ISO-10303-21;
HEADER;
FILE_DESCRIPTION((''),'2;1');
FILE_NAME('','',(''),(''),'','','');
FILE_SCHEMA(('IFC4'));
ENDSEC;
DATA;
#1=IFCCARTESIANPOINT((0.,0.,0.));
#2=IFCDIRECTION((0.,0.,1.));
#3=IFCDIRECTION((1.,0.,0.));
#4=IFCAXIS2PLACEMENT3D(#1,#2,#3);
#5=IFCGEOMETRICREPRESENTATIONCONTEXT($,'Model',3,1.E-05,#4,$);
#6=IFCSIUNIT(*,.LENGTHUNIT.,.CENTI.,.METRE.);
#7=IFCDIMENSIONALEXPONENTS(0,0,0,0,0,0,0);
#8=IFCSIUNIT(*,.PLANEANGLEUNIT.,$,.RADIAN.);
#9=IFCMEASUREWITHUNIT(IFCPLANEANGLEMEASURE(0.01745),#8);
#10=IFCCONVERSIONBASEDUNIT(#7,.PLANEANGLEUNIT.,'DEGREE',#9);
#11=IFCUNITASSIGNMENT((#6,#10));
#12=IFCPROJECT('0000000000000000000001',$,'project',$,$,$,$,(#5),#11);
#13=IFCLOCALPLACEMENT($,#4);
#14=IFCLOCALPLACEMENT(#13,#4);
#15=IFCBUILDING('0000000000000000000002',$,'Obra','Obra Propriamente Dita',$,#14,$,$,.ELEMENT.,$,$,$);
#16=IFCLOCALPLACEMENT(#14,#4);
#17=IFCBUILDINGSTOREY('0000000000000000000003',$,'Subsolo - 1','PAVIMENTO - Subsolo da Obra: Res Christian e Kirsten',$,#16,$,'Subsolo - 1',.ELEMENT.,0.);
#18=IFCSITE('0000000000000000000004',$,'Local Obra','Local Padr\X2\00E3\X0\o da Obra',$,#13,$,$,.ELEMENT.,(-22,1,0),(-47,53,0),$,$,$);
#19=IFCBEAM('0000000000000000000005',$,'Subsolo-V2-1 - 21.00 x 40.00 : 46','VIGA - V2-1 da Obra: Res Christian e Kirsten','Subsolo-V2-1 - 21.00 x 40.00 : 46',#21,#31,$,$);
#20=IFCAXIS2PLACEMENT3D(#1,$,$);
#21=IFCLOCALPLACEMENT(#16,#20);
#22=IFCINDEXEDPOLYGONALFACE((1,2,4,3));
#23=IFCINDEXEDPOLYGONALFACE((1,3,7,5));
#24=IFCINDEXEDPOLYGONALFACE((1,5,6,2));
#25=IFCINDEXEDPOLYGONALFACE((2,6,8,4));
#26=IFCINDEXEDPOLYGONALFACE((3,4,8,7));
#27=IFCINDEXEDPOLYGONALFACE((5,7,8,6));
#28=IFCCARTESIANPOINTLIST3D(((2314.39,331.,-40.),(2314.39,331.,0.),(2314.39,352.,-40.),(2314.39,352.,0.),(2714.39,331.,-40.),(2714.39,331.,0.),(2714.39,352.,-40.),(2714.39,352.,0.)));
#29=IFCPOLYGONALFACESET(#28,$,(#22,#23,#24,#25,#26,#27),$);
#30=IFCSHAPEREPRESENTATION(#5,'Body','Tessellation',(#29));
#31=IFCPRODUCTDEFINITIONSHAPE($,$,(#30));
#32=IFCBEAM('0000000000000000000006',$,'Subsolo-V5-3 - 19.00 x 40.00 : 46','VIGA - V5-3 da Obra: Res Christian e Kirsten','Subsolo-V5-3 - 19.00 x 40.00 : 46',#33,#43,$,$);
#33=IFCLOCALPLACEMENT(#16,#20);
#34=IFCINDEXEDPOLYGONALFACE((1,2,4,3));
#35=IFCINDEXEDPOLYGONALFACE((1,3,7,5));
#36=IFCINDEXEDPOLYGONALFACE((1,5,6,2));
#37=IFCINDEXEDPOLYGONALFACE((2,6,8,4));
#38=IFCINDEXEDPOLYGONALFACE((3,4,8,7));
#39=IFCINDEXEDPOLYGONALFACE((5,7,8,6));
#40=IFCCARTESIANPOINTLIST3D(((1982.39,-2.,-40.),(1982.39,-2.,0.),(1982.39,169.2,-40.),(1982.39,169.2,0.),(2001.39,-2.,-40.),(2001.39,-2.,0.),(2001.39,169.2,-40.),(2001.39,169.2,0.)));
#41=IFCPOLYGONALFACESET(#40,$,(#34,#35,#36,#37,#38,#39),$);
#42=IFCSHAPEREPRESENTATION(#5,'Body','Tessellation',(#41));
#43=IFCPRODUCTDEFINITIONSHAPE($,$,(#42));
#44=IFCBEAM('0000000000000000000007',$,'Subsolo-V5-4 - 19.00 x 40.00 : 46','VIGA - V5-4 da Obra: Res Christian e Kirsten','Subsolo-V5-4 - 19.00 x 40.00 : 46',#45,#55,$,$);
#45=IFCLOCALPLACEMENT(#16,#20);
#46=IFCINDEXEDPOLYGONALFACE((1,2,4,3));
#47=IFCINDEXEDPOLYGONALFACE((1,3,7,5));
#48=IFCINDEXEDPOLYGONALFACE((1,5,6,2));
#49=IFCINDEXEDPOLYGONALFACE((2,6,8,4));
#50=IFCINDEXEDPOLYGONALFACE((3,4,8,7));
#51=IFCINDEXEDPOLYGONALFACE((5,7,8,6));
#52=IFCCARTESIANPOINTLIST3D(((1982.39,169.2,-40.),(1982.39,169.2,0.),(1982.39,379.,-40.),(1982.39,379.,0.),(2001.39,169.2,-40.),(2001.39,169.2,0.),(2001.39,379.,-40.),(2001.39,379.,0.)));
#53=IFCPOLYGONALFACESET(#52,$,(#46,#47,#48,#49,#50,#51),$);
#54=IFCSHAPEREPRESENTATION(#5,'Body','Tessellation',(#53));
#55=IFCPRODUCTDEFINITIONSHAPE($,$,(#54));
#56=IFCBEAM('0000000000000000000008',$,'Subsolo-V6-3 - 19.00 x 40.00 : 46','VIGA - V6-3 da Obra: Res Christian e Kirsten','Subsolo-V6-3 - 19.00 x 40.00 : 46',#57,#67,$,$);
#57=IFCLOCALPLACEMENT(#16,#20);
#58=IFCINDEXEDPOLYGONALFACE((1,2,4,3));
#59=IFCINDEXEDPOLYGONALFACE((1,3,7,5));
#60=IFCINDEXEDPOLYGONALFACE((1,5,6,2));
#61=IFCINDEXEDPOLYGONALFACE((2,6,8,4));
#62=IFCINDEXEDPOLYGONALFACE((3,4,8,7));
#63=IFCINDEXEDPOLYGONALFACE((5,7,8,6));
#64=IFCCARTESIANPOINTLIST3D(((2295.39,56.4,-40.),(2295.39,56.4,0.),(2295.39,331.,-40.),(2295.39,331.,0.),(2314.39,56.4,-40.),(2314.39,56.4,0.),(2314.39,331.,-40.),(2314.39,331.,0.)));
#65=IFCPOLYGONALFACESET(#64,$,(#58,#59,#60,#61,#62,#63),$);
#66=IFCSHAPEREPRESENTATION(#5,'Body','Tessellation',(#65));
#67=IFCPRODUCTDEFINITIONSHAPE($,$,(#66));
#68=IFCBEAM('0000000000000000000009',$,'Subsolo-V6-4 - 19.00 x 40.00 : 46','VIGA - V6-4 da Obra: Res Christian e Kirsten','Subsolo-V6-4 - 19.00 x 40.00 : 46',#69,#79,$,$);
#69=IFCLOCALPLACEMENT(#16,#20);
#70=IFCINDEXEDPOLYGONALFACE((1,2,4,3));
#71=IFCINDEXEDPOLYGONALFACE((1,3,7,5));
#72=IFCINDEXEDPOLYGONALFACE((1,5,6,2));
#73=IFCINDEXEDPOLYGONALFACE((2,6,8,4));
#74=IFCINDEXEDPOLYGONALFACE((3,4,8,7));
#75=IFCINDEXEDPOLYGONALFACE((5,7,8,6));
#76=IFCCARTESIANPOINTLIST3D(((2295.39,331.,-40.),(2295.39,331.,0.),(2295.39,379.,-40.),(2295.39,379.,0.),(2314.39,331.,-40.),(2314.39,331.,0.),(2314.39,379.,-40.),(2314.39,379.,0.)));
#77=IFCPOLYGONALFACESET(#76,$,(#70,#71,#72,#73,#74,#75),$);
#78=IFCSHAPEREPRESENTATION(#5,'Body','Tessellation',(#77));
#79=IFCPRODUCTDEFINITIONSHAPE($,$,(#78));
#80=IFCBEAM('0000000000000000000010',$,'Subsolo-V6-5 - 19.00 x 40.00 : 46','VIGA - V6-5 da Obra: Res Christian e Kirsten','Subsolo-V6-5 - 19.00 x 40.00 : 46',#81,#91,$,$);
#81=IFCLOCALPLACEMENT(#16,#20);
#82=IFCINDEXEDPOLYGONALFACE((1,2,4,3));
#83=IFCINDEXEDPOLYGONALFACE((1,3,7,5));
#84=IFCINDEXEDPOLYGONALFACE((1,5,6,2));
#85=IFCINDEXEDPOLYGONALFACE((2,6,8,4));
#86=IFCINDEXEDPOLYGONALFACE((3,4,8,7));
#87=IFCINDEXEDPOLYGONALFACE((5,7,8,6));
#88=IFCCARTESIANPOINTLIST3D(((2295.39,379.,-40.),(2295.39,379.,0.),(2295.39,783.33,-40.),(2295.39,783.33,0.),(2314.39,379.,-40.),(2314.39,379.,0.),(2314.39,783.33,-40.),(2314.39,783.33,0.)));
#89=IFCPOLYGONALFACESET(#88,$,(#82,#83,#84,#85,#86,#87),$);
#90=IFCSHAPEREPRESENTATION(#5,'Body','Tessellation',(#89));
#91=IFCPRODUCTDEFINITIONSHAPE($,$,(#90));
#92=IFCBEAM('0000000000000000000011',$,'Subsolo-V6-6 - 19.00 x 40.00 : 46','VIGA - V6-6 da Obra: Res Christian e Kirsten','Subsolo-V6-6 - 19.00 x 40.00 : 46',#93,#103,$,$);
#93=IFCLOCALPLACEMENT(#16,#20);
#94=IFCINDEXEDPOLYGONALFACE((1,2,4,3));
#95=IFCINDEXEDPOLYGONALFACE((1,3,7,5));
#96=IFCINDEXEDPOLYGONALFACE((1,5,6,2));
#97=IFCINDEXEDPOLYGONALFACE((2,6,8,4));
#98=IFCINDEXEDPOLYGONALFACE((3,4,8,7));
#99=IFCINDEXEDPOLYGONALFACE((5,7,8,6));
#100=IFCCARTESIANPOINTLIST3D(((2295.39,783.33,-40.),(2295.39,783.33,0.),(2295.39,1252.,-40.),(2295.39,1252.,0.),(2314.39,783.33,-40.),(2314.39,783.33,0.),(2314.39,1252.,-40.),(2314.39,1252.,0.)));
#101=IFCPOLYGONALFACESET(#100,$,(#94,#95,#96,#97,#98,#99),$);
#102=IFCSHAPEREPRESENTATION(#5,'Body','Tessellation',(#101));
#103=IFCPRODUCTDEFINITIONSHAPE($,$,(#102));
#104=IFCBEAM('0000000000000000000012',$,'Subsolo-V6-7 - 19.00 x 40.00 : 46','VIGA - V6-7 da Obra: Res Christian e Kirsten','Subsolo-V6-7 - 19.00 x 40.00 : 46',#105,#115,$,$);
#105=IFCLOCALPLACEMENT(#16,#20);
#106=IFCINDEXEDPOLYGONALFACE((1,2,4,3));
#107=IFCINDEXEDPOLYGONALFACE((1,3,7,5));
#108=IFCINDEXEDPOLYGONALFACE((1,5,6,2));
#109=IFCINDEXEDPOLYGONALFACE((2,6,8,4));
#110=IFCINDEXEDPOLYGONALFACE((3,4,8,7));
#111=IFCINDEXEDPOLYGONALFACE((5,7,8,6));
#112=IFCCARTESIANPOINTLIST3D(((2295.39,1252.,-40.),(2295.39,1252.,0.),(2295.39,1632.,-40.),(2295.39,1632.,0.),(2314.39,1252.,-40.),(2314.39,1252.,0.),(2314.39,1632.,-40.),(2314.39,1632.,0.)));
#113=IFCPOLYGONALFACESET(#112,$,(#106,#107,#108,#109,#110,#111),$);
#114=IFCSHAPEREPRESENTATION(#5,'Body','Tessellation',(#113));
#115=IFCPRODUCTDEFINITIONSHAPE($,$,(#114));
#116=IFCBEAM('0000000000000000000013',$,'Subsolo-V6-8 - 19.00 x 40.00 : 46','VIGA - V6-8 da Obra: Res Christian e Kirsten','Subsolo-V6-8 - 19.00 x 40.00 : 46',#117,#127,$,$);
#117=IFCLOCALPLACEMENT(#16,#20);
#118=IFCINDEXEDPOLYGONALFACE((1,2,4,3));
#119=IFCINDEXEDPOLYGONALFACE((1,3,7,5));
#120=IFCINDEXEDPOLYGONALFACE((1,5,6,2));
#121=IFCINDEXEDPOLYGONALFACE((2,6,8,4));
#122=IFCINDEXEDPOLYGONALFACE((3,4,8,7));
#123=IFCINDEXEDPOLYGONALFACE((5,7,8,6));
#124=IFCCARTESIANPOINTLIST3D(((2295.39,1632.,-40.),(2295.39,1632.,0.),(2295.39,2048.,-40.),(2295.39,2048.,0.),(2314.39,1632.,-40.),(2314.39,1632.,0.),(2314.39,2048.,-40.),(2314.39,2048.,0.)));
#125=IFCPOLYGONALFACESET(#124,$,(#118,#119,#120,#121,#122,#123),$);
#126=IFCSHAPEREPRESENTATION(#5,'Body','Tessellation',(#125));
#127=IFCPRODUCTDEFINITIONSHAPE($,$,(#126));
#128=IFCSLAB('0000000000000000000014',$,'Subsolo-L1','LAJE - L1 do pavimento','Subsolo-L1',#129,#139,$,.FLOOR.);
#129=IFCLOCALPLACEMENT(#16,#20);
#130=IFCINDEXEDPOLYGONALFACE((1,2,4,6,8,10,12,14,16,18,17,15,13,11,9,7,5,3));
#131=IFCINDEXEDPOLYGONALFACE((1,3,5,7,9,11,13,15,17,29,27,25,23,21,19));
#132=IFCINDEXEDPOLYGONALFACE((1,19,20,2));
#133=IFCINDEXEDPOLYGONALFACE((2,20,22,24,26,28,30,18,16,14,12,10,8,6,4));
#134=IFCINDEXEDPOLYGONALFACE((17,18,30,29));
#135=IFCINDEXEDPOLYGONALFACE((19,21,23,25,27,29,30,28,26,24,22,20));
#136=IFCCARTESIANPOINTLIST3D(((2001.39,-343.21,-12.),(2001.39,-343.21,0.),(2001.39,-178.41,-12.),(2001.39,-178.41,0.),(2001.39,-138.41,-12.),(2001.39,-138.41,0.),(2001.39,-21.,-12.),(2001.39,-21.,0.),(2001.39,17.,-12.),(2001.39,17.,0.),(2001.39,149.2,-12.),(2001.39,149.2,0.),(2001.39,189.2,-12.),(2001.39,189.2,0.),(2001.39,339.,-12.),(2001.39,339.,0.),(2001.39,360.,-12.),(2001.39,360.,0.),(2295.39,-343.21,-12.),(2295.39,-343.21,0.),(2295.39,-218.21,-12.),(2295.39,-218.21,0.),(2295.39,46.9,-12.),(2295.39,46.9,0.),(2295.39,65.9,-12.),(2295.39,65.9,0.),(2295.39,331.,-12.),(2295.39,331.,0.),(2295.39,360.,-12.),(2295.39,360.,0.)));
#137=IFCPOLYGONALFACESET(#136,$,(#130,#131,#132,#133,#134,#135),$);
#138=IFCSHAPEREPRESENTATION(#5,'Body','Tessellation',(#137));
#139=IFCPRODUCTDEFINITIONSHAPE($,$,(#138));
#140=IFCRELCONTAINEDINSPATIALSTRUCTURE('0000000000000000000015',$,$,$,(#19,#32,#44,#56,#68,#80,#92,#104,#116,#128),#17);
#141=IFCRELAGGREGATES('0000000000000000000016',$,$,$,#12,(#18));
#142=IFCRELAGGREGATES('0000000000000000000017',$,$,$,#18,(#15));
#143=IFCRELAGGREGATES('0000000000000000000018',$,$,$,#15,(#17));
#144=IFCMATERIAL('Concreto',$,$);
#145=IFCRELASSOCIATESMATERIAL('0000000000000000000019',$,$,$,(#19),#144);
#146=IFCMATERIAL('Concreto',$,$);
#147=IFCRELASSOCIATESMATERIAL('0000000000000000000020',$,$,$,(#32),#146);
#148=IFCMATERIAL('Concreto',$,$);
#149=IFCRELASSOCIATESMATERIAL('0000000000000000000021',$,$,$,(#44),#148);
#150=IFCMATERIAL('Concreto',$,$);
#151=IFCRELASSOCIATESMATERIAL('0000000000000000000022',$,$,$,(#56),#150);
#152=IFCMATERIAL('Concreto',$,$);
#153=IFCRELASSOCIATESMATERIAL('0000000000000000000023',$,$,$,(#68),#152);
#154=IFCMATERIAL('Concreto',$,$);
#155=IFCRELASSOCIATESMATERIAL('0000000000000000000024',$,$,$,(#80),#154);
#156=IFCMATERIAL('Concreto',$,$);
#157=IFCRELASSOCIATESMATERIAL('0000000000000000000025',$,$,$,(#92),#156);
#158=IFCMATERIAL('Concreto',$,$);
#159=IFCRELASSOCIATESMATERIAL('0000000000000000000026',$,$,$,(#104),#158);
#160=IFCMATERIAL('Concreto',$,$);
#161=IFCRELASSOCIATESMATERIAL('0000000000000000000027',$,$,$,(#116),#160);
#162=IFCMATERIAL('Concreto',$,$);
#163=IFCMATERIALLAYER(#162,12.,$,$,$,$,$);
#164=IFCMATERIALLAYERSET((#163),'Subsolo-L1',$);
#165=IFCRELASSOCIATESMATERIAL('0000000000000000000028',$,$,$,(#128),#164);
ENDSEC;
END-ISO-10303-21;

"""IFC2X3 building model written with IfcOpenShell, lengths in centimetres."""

from ifc_helpers import new_model, entity, si_unit, converted_unit, frame, origin_with_axes, place, context, project, spatial, polyline, outline, extrude, material, layer, layer_set, layer_usage, element, save


model = new_model("IFC2X3")

# Units and contexts
model_context = context("Model", 3, precision=1e-05, world=origin_with_axes())
ifc_project = project(units=[si_unit("LENGTHUNIT", "METRE", prefix="CENTI"), converted_unit("PLANEANGLEUNIT", "DEGREE", entity("IfcPlaneAngleMeasure", 0.01745), si_unit("PLANEANGLEUNIT", "RADIAN"), dimensions=[0, 0, 0, 0, 0, 0, 0])], contexts=[model_context])

# Site, building, storey
site_placement = place(None, origin_with_axes())
site = spatial("IfcSite", under=ifc_project, at=site_placement, Name="Local Obra", Description="Local Padrão da Obra", CompositionType="ELEMENT", RefLatitude=(-22, 1, 0), RefLongitude=(-47, 53, 0))
building_placement = place(site_placement, origin_with_axes())
building = spatial("IfcBuilding", under=site, at=building_placement, Name="Obra", Description="Obra Propriamente Dita", CompositionType="ELEMENT")
storey_placement = place(building_placement, origin_with_axes())
storey = spatial("IfcBuildingStorey", under=building, at=storey_placement, Name="Subsolo - 1", Description="PAVIMENTO - Subsolo da Obra: Res Christian e Kirsten", LongName="Subsolo - 1", CompositionType="ELEMENT", Elevation=0.0)

# Beams
ifc_material_1 = material(Name="Concreto")
beam_1_placement = place(storey_placement, frame((2314.39, 331.0, 0.0), z_axis=(1.0, 0.0, 0.0), x_axis=(0.0, -1.0, 0.0)))
element("IfcBeam", 1, at=beam_1_placement, inside=storey, material=ifc_material_1, Name="Subsolo-V2-1 - 21.00 x 40.00 : 46", Description="VIGA - V2-1 da Obra: Res Christian e Kirsten", ObjectType="Subsolo-V2-1 - 21.00 x 40.00 : 46", context=model_context, shape_type="SweptSolid", body=[
    extrude(outline(polyline([(-21.0, 0.0), (0.0, 0.0), (0.0, 40.0), (-21.0, 40.0), (-21.0, 0.0)])), origin_with_axes(), (0.0, 0.0, 1.0), 400.0),
])
ifc_material_2 = material(Name="Concreto")
beam_2_placement = place(storey_placement, frame((2001.39, -2.0, 0.0), z_axis=(0.0, 1.0, 0.0), x_axis=(1.0, 0.0, 0.0)))
element("IfcBeam", 2, at=beam_2_placement, inside=storey, material=ifc_material_2, Name="Subsolo-V5-3 - 19.00 x 40.00 : 46", Description="VIGA - V5-3 da Obra: Res Christian e Kirsten", ObjectType="Subsolo-V5-3 - 19.00 x 40.00 : 46", context=model_context, shape_type="SweptSolid", body=[
    extrude(outline(polyline([(-19.0, 0.0), (0.0, 0.0), (0.0, 40.0), (-19.0, 40.0), (-19.0, 0.0)])), origin_with_axes(), (0.0, 0.0, 1.0), 171.2),
])
ifc_material_3 = material(Name="Concreto")
beam_3_placement = place(storey_placement, frame((2001.39, 169.2, 0.0), z_axis=(0.0, 1.0, 0.0), x_axis=(1.0, 0.0, 0.0)))
element("IfcBeam", 3, at=beam_3_placement, inside=storey, material=ifc_material_3, Name="Subsolo-V5-4 - 19.00 x 40.00 : 46", Description="VIGA - V5-4 da Obra: Res Christian e Kirsten", ObjectType="Subsolo-V5-4 - 19.00 x 40.00 : 46", context=model_context, shape_type="SweptSolid", body=[
    extrude(outline(polyline([(-19.0, 0.0), (0.0, 0.0), (0.0, 40.0), (-19.0, 40.0), (-19.0, 0.0)])), origin_with_axes(), (0.0, 0.0, 1.0), 209.8),
])
ifc_material_4 = material(Name="Concreto")
beam_4_placement = place(storey_placement, frame((2314.39, 56.4, 0.0), z_axis=(-0.000004, 1.0, 0.0), x_axis=(1.0, 0.000004, 0.0)))
element("IfcBeam", 4, at=beam_4_placement, inside=storey, material=ifc_material_4, Name="Subsolo-V6-3 - 19.00 x 40.00 : 46", Description="VIGA - V6-3 da Obra: Res Christian e Kirsten", ObjectType="Subsolo-V6-3 - 19.00 x 40.00 : 46", context=model_context, shape_type="SweptSolid", body=[
    extrude(outline(polyline([(-19.0, 0.0), (0.0, 0.0), (0.0, 40.0), (-19.0, 40.0), (-19.0, 0.0)])), origin_with_axes(), (0.0, 0.0, 1.0), 274.6),
])
ifc_material_5 = material(Name="Concreto")
beam_5_placement = place(storey_placement, frame((2314.39, 331.0, 0.0), z_axis=(0.0, 1.0, 0.0), x_axis=(1.0, 0.0, 0.0)))
element("IfcBeam", 5, at=beam_5_placement, inside=storey, material=ifc_material_5, Name="Subsolo-V6-4 - 19.00 x 40.00 : 46", Description="VIGA - V6-4 da Obra: Res Christian e Kirsten", ObjectType="Subsolo-V6-4 - 19.00 x 40.00 : 46", context=model_context, shape_type="SweptSolid", body=[
    extrude(outline(polyline([(-19.0, 0.0), (0.0, 0.0), (0.0, 40.0), (-19.0, 40.0), (-19.0, 0.0)])), origin_with_axes(), (0.0, 0.0, 1.0), 48.0),
])
ifc_material_6 = material(Name="Concreto")
beam_6_placement = place(storey_placement, frame((2314.39, 379.0, 0.0), z_axis=(0.000002, 1.0, 0.0), x_axis=(1.0, -0.000002, 0.0)))
element("IfcBeam", 6, at=beam_6_placement, inside=storey, material=ifc_material_6, Name="Subsolo-V6-5 - 19.00 x 40.00 : 46", Description="VIGA - V6-5 da Obra: Res Christian e Kirsten", ObjectType="Subsolo-V6-5 - 19.00 x 40.00 : 46", context=model_context, shape_type="SweptSolid", body=[
    extrude(outline(polyline([(-19.0, 0.0), (0.0, 0.0), (0.0, 40.0), (-19.0, 40.0), (-19.0, 0.0)])), origin_with_axes(), (0.0, 0.0, 1.0), 404.33),
])
ifc_material_7 = material(Name="Concreto")
beam_7_placement = place(storey_placement, frame((2314.39, 783.33, 0.0), z_axis=(0.0, 1.0, 0.0), x_axis=(1.0, 0.0, 0.0)))
element("IfcBeam", 7, at=beam_7_placement, inside=storey, material=ifc_material_7, Name="Subsolo-V6-6 - 19.00 x 40.00 : 46", Description="VIGA - V6-6 da Obra: Res Christian e Kirsten", ObjectType="Subsolo-V6-6 - 19.00 x 40.00 : 46", context=model_context, shape_type="SweptSolid", body=[
    extrude(outline(polyline([(-19.0, 0.0), (0.0, 0.0), (0.0, 40.0), (-19.0, 40.0), (-19.0, 0.0)])), origin_with_axes(), (0.0, 0.0, 1.0), 468.67),
])
ifc_material_8 = material(Name="Concreto")
beam_8_placement = place(storey_placement, frame((2314.39, 1252.0, 0.0), z_axis=(-0.000003, 1.0, 0.0), x_axis=(1.0, 0.000003, 0.0)))
element("IfcBeam", 8, at=beam_8_placement, inside=storey, material=ifc_material_8, Name="Subsolo-V6-7 - 19.00 x 40.00 : 46", Description="VIGA - V6-7 da Obra: Res Christian e Kirsten", ObjectType="Subsolo-V6-7 - 19.00 x 40.00 : 46", context=model_context, shape_type="SweptSolid", body=[
    extrude(outline(polyline([(-19.0, 0.0), (0.0, 0.0), (0.0, 40.0), (-19.0, 40.0), (-19.0, 0.0)])), origin_with_axes(), (0.0, 0.0, 1.0), 380.0),
])
ifc_material_9 = material(Name="Concreto")
beam_9_placement = place(storey_placement, frame((2314.39, 1632.0, 0.0), z_axis=(0.0, 1.0, 0.0), x_axis=(1.0, 0.0, 0.0)))
element("IfcBeam", 9, at=beam_9_placement, inside=storey, material=ifc_material_9, Name="Subsolo-V6-8 - 19.00 x 40.00 : 46", Description="VIGA - V6-8 da Obra: Res Christian e Kirsten", ObjectType="Subsolo-V6-8 - 19.00 x 40.00 : 46", context=model_context, shape_type="SweptSolid", body=[
    extrude(outline(polyline([(-19.0, 0.0), (0.0, 0.0), (0.0, 40.0), (-19.0, 40.0), (-19.0, 0.0)])), origin_with_axes(), (0.0, 0.0, 1.0), 416.0),
])

# Slab
ifc_material_10 = material(Name="Concreto")
ifc_layer = layer(ifc_material_10, 12.0)
ifc_layer_set = layer_set([ifc_layer], Name="Subsolo-L1")
ifc_layer_usage = layer_usage(ifc_layer_set, "AXIS3", "POSITIVE", 0.0)
slab_placement = place(storey_placement, frame((2295.39, 331.0, -12.0), z_axis=(0.0, 0.0, 1.0), x_axis=(1.0, 0.0, 0.0)))
element("IfcSlab", 10, at=slab_placement, inside=storey, material=ifc_layer_usage, Name="Subsolo-L1", Description="LAJE - L1 do pavimento", ObjectType="Subsolo-L1", PredefinedType="FLOOR", context=model_context, shape_type="SweptSolid", body=[
    extrude(outline(polyline([(0.0, 29.0), (-294.0, 29.0), (-294.0, 8.0), (-294.0, -141.8), (-294.0, -181.8), (-294.0, -314.0), (-294.0, -352.0), (-294.0, -469.41), (-294.0, -509.41), (-294.0, -674.21), (0.0, -674.21), (0.0, -549.21), (0.0, -284.1), (0.0, -265.1), (0.0, 0.0), (0.0, 29.0)])), origin_with_axes(), (0.0, 0.0, 1.0), 12.0),
])

save(model, "model.ifc")
